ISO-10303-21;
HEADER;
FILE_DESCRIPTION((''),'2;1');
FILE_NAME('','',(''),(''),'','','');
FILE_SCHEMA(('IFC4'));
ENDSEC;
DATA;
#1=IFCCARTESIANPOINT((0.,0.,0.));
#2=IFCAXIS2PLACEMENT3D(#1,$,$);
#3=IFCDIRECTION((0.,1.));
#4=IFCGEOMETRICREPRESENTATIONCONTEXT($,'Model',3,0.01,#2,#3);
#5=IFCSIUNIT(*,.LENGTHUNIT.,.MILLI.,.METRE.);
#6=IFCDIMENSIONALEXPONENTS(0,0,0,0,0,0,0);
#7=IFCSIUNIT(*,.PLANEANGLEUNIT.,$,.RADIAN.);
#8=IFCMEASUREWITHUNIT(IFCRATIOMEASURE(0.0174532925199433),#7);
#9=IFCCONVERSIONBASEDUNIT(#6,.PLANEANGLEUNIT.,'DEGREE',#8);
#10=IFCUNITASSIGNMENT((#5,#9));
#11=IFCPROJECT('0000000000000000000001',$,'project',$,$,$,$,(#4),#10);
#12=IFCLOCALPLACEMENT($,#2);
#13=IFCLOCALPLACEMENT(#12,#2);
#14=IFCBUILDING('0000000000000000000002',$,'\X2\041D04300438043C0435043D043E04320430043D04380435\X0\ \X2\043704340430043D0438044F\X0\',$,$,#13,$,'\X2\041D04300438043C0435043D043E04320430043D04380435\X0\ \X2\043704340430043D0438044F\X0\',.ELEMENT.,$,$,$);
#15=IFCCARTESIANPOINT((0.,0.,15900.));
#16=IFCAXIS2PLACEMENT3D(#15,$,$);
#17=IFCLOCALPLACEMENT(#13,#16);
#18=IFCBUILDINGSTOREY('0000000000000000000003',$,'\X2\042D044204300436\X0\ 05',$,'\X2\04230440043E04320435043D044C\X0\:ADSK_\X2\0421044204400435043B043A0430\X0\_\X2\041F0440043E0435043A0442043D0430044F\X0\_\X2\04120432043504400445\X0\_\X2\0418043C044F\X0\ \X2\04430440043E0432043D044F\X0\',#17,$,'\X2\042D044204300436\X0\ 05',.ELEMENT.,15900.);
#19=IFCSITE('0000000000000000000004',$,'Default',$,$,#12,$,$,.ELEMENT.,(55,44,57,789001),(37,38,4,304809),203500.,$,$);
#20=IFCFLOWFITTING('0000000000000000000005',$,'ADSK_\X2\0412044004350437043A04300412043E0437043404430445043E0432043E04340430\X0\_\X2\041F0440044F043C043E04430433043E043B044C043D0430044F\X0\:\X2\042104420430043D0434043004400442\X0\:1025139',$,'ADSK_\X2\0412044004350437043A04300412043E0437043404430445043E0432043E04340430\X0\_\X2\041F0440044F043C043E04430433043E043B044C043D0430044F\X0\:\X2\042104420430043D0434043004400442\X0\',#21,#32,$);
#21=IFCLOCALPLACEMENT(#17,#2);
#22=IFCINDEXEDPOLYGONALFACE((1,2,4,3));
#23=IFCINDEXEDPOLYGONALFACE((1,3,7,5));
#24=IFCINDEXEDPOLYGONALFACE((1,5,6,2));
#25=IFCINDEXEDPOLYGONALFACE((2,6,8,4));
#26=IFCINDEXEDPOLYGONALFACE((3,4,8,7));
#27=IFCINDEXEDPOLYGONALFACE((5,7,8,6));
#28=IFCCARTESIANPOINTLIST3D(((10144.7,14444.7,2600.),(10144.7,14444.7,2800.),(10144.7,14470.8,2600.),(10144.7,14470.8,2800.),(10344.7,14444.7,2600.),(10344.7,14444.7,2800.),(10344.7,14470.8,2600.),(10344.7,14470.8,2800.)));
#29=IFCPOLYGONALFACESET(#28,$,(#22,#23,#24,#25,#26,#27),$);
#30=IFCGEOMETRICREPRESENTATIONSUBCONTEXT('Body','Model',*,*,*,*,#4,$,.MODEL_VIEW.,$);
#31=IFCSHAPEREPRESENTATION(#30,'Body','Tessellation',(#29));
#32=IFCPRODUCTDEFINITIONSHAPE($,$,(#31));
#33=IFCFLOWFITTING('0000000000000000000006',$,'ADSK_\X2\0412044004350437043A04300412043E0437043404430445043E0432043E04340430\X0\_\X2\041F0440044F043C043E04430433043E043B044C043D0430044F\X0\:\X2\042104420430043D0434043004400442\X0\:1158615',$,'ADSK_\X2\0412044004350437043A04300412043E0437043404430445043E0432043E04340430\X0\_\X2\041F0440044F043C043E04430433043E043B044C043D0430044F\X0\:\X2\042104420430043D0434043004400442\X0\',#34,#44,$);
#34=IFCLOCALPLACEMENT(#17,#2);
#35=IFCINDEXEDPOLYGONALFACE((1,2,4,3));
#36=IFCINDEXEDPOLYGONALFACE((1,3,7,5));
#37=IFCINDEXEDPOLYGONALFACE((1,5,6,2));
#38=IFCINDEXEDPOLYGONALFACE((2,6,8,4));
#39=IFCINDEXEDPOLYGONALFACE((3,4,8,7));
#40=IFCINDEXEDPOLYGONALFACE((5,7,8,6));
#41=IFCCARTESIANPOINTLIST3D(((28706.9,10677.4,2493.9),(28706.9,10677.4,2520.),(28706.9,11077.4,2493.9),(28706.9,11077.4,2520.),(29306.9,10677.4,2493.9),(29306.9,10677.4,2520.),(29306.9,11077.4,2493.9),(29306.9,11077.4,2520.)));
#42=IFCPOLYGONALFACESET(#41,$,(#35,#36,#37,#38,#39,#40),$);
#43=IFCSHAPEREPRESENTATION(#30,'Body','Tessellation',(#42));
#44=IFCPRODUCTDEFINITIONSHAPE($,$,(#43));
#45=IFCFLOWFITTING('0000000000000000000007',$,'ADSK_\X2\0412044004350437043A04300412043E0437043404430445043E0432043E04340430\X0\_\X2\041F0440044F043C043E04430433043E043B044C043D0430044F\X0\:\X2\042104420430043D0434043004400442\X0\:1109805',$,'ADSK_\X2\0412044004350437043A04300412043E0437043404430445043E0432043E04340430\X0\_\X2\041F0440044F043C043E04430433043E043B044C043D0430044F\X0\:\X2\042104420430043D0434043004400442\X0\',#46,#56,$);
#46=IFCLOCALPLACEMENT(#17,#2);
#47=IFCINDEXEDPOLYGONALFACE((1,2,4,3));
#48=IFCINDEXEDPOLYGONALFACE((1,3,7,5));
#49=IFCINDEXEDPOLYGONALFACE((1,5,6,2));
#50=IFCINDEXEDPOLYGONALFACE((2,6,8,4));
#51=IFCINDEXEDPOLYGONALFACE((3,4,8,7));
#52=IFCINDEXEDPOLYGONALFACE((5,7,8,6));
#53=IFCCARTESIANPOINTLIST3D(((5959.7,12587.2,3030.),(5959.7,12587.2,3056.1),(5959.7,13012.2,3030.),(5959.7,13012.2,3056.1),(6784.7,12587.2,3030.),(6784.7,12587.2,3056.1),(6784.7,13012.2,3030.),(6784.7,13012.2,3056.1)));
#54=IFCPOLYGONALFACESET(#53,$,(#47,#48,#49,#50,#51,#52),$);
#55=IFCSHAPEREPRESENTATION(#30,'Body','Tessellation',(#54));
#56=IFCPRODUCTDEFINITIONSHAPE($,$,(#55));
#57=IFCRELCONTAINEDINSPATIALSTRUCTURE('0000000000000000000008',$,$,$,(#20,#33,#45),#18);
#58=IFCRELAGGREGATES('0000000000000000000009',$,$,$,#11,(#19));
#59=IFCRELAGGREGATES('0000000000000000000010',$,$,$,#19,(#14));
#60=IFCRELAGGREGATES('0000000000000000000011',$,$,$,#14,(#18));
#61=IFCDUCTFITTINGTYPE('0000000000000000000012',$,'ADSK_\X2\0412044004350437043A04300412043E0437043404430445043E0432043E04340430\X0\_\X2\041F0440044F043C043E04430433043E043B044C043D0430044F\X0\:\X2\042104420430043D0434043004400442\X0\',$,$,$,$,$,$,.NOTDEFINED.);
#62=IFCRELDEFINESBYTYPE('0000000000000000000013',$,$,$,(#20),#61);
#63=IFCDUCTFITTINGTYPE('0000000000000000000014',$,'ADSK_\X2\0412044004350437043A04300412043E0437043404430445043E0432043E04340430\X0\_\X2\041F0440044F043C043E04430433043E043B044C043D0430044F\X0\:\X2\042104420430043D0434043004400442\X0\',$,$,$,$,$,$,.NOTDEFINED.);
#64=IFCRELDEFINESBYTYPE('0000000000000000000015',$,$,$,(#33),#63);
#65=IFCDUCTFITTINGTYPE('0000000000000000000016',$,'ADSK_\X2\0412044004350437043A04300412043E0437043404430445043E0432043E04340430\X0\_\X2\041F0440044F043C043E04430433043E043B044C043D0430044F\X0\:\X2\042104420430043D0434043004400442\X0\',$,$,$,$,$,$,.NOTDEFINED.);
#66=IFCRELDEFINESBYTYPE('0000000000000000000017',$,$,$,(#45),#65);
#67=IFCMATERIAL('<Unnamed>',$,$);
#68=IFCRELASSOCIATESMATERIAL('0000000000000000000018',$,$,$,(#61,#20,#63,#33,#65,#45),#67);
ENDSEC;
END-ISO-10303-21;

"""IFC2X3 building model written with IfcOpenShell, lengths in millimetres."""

from ifc_helpers import new_model, entity, si_unit, converted_unit, direction, frame, frame_2d, origin, place, context, subcontext, project, spatial, rectangle, extrude, source, transform, mapped, material, type_object, type_shapes, element, save


model = new_model("IFC2X3")

# Units and contexts
model_context = context("Model", 3, precision=0.01, world=origin(), true_north=direction((0.0, 1.0)))
body_context = subcontext(model_context, "Body", "Model", "MODEL_VIEW")
ifc_project = project(units=[si_unit("LENGTHUNIT", "METRE", prefix="MILLI"), converted_unit("PLANEANGLEUNIT", "DEGREE", entity("IfcRatioMeasure", 0.0174532925199433), si_unit("PLANEANGLEUNIT", "RADIAN"), dimensions=[0, 0, 0, 0, 0, 0, 0])], contexts=[model_context])

# Site, building, storey
site_placement = place(None, frame((0.0, 0.0, 0.0)))
site = spatial("IfcSite", under=ifc_project, at=site_placement, Name="Default", CompositionType="ELEMENT", RefLatitude=(55, 44, 57, 789001), RefLongitude=(37, 38, 4, 304809), RefElevation=203500.0)
building_placement = place(site_placement, origin())
building = spatial("IfcBuilding", under=site, at=building_placement, Name="Наименование здания", LongName="Наименование здания", CompositionType="ELEMENT")
storey_placement = place(building_placement, frame((0.0, 0.0, 15900.0)))
storey = spatial("IfcBuildingStorey", under=building, at=storey_placement, Name="Этаж 05", ObjectType="Уровень:ADSK_Стрелка_Проектная_Вверх_Имя уровня", LongName="Этаж 05", CompositionType="ELEMENT", Elevation=15900.0)

# Shared definitions
ifc_material_1 = material(Name="<Unnamed>")

# Flow fittings
duct_fitting_type_1 = type_object("IfcDuctFittingType", Name="ADSK_ВрезкаВоздуховода_Прямоугольная:Стандарт", PredefinedType="NOTDEFINED", material=ifc_material_1)
shared_shape_1 = source(origin(), body_context, "Body", "SweptSolid", [
    extrude(rectangle(XDim=200.0, YDim=26.1, at=frame_2d((0.0, 0.0), x_axis=(1.0, 0.0))), frame((7.0, 0.0, -100.0), z_axis=(0.0, 0.0, 1.0), x_axis=(0.0, -1.0, 0.0)), (0.0, 0.0, 1.0), 200.0),
])
type_shapes(duct_fitting_type_1, [shared_shape_1])
flow_fitting_1_placement = place(storey_placement, frame((10244.7, 14450.8, 2700.0), z_axis=(1.0, 0.0, 0.0), x_axis=(0.0, 1.0, 0.0)))
element("IfcFlowFitting", 1, at=flow_fitting_1_placement, inside=storey, type_object=duct_fitting_type_1, material=ifc_material_1, Name="ADSK_ВрезкаВоздуховода_Прямоугольная:Стандарт:1025139", ObjectType="ADSK_ВрезкаВоздуховода_Прямоугольная:Стандарт", context=body_context, shape_type="MappedRepresentation", body=[
    mapped(shared_shape_1, transform((0.0, 0.0, 0.0), scale=1.0)),
])
duct_fitting_type_2 = type_object("IfcDuctFittingType", Name="ADSK_ВрезкаВоздуховода_Прямоугольная:Стандарт", PredefinedType="NOTDEFINED", material=ifc_material_1)
shared_shape_2 = source(origin(), body_context, "Body", "SweptSolid", [
    extrude(rectangle(XDim=26.1, YDim=400.0, at=frame_2d((0.0, 0.0), x_axis=(1.0, 0.0))), frame((7.0, 0.0, -300.0)), (0.0, 0.0, 1.0), 600.0),
])
type_shapes(duct_fitting_type_2, [shared_shape_2])
flow_fitting_2_placement = place(storey_placement, frame((29006.9, 10877.4, 2500.0), z_axis=(1.0, 0.0, 0.0), x_axis=(0.0, 0.0, 1.0)))
element("IfcFlowFitting", 2, at=flow_fitting_2_placement, inside=storey, type_object=duct_fitting_type_2, material=ifc_material_1, Name="ADSK_ВрезкаВоздуховода_Прямоугольная:Стандарт:1158615", ObjectType="ADSK_ВрезкаВоздуховода_Прямоугольная:Стандарт", context=body_context, shape_type="MappedRepresentation", body=[
    mapped(shared_shape_2, transform((0.0, 0.0, 0.0), scale=1.0)),
])
duct_fitting_type_3 = type_object("IfcDuctFittingType", Name="ADSK_ВрезкаВоздуховода_Прямоугольная:Стандарт", PredefinedType="NOTDEFINED", material=ifc_material_1)
shared_shape_3 = source(origin(), body_context, "Body", "SweptSolid", [
    extrude(rectangle(XDim=825.0, YDim=26.1, at=frame_2d((0.0, 0.0), x_axis=(1.0, 0.0))), frame((7.0, 0.0, -212.5), z_axis=(0.0, 0.0, 1.0), x_axis=(0.0, -1.0, 0.0)), (0.0, 0.0, 1.0), 425.0),
])
type_shapes(duct_fitting_type_3, [shared_shape_3])
flow_fitting_3_placement = place(storey_placement, frame((6372.2, 12799.7, 3050.0), z_axis=(0.0, -1.0, 0.0), x_axis=(0.0, 0.0, -1.0)))
element("IfcFlowFitting", 3, at=flow_fitting_3_placement, inside=storey, type_object=duct_fitting_type_3, material=ifc_material_1, Name="ADSK_ВрезкаВоздуховода_Прямоугольная:Стандарт:1109805", ObjectType="ADSK_ВрезкаВоздуховода_Прямоугольная:Стандарт", context=body_context, shape_type="MappedRepresentation", body=[
    mapped(shared_shape_3, transform((0.0, 0.0, 0.0), scale=1.0)),
])

save(model, "model.ifc")
